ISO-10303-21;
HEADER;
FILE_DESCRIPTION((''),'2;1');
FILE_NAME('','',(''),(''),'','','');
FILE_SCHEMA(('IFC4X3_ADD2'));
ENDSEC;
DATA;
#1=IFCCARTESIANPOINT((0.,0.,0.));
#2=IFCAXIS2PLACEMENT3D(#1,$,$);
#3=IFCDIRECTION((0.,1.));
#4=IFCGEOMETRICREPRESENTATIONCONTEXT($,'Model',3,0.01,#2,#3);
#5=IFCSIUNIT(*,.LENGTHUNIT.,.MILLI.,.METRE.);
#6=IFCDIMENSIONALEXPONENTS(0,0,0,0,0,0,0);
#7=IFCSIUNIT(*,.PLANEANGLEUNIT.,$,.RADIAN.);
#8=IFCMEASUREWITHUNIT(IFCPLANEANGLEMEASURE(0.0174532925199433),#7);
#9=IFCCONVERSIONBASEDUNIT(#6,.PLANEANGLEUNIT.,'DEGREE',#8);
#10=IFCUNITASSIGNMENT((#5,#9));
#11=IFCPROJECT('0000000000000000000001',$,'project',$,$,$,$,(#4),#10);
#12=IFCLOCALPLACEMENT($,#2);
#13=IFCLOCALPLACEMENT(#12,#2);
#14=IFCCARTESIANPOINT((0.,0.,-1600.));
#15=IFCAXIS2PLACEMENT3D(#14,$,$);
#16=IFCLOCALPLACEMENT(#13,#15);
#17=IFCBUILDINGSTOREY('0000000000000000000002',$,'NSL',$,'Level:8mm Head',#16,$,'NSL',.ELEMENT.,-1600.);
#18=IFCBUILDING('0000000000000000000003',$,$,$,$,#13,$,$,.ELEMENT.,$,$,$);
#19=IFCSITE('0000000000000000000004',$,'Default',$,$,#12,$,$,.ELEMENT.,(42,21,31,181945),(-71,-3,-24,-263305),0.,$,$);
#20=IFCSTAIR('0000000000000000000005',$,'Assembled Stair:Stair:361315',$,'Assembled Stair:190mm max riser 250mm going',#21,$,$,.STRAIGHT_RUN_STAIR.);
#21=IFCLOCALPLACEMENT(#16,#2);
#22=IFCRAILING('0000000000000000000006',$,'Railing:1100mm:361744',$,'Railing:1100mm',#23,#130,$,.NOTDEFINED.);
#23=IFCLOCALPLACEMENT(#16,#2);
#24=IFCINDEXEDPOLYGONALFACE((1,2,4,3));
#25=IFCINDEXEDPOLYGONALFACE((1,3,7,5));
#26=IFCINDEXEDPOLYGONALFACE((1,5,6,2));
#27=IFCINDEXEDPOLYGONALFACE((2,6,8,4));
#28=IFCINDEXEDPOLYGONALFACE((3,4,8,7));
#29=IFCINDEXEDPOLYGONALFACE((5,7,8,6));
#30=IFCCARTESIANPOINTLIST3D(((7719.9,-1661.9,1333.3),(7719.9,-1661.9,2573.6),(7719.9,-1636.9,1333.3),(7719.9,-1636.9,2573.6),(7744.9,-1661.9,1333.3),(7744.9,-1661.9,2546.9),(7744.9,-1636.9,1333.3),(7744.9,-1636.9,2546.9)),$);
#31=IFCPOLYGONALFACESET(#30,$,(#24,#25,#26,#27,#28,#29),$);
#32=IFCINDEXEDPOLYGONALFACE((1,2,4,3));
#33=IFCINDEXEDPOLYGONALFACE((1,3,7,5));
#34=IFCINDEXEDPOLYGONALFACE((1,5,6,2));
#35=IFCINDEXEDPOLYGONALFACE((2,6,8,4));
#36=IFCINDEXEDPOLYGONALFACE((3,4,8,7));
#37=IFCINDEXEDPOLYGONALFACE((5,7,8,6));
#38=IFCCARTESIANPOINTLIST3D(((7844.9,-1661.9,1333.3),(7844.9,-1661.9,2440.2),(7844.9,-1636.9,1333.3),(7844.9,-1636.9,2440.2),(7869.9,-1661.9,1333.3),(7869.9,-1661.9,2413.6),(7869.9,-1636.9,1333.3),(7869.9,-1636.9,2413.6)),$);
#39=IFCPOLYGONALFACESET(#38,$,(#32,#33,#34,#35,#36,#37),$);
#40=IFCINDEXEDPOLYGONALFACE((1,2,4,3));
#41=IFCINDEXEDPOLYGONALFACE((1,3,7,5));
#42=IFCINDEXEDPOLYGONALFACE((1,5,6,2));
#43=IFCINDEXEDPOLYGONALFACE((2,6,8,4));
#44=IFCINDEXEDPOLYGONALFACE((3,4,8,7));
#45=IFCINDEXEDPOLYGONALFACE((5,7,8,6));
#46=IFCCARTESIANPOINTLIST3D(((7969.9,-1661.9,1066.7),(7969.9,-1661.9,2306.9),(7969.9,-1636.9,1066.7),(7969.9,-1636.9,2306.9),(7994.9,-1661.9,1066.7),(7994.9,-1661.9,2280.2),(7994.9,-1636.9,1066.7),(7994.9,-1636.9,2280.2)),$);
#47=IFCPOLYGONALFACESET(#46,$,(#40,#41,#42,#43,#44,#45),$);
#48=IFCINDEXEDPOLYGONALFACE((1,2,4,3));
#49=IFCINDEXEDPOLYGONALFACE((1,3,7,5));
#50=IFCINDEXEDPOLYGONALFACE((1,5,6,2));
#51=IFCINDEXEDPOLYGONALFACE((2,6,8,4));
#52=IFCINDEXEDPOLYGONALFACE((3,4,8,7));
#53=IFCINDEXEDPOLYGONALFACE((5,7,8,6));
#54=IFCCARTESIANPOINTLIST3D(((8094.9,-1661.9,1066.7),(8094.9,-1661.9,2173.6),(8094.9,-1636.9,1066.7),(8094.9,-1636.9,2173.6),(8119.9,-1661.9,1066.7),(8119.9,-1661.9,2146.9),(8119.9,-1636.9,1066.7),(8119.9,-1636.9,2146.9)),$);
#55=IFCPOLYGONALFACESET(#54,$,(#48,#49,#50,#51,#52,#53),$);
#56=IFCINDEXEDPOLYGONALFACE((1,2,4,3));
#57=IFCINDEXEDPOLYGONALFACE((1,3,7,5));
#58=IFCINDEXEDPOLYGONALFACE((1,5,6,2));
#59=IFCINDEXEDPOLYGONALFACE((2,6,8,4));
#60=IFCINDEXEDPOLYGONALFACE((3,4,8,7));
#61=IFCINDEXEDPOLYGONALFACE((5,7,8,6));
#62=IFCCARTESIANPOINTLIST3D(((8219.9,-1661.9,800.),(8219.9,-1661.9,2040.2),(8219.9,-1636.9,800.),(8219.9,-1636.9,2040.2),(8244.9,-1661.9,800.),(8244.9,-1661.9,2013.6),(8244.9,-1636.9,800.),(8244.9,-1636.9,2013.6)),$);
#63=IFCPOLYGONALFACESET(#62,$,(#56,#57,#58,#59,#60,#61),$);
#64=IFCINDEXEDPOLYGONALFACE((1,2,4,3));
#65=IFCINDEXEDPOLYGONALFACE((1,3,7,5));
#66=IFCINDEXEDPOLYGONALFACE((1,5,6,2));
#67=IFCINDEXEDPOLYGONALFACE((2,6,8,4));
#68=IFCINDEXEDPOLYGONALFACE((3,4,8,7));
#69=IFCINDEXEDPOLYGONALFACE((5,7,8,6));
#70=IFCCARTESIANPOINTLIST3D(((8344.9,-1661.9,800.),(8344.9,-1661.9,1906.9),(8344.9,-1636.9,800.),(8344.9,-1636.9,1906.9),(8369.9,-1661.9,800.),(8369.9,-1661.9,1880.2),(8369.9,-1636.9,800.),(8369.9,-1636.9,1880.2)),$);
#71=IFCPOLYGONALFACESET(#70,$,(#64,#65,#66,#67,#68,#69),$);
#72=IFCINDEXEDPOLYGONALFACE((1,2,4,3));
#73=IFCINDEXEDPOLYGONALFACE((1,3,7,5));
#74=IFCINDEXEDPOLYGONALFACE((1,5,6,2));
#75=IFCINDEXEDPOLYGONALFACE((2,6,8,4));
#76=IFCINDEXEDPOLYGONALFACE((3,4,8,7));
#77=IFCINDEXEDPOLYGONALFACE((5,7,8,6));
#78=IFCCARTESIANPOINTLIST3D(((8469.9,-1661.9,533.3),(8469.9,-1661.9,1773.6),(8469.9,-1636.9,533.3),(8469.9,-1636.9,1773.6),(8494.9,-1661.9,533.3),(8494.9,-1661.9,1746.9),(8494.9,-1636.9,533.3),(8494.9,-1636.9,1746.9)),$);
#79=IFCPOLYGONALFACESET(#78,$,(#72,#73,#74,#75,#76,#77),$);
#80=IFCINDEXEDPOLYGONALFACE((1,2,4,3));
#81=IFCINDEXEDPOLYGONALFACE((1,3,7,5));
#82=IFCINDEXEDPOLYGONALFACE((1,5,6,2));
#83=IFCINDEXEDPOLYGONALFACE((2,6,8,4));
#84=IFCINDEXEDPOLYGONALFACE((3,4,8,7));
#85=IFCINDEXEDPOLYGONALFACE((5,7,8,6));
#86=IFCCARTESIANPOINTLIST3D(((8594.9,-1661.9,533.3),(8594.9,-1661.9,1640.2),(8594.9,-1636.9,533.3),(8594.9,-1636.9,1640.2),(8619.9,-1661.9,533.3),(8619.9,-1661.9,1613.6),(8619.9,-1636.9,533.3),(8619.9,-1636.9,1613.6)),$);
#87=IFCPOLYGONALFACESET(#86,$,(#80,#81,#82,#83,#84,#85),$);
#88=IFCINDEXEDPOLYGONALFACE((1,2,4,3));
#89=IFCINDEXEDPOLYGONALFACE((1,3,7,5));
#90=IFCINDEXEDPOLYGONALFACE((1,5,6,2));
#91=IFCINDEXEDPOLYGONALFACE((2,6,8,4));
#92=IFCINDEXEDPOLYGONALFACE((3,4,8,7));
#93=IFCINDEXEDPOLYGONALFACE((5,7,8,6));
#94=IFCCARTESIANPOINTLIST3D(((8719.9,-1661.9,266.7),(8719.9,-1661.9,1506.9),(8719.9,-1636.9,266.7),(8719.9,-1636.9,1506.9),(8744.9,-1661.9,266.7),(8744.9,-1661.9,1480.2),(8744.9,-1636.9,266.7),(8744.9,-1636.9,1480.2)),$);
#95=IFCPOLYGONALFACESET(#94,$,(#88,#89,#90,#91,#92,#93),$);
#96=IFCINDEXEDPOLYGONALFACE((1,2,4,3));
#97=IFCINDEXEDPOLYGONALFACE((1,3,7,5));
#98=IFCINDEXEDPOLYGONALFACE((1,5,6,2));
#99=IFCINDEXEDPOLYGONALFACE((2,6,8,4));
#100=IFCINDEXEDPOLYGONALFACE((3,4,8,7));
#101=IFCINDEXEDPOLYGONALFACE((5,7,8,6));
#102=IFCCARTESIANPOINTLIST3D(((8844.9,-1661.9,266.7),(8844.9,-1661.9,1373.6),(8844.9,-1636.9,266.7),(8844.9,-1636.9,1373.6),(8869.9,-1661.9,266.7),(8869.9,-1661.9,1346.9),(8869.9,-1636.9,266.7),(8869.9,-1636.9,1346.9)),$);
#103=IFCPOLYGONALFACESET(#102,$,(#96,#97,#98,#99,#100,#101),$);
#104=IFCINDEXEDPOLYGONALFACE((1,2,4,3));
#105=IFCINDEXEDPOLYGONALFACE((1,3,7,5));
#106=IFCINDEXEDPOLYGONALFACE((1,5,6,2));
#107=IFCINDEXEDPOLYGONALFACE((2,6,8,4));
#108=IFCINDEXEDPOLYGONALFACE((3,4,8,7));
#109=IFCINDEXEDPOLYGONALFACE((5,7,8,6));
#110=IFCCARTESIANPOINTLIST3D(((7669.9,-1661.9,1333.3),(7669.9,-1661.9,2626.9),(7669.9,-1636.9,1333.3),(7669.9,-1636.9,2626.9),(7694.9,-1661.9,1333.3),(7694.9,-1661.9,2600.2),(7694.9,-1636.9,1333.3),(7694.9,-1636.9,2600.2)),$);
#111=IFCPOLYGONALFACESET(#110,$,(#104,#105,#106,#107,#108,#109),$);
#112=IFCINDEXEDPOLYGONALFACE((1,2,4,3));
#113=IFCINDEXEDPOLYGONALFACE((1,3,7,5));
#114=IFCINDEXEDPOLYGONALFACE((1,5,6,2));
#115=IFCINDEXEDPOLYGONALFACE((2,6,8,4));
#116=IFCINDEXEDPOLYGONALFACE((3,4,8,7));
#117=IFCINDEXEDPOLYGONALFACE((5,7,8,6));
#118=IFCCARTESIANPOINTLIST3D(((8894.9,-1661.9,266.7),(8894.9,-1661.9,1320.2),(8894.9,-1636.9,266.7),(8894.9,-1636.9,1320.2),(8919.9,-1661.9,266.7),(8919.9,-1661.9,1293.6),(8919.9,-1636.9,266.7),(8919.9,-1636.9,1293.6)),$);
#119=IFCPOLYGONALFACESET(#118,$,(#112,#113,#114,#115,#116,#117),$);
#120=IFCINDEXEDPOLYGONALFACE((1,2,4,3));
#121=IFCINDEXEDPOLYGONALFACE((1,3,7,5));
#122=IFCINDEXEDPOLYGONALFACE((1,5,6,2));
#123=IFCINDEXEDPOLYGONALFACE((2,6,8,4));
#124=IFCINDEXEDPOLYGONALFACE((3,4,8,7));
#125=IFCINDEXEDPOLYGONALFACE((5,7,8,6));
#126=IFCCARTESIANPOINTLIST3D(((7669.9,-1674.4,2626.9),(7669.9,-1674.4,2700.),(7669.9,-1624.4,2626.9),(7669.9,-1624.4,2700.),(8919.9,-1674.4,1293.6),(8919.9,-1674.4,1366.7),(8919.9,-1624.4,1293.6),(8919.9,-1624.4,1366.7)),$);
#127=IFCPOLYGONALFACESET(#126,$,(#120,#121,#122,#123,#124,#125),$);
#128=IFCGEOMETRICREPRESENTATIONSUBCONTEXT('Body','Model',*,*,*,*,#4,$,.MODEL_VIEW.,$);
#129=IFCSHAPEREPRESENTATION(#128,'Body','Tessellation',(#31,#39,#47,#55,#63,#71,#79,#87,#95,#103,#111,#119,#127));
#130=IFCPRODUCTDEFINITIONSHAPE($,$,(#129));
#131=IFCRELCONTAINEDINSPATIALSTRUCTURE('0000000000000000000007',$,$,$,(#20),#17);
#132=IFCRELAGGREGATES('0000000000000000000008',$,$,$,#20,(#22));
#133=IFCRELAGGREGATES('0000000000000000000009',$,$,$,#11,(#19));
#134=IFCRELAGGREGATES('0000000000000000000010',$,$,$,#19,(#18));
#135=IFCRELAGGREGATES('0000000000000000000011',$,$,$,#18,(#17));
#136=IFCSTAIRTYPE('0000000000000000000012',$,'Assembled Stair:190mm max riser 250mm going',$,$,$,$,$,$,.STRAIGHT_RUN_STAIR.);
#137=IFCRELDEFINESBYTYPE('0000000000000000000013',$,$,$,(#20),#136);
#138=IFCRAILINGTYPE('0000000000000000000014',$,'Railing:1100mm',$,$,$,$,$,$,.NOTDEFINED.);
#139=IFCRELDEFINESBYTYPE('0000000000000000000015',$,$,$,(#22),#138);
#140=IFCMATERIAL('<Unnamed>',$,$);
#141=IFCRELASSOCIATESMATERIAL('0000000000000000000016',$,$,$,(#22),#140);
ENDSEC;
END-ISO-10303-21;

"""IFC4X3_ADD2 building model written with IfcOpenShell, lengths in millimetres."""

from ifc_helpers import new_model, entity, si_unit, converted_unit, direction, frame, origin, place, context, subcontext, project, spatial, polyline, outline, extrude, material, type_object, element, aggregate, save


model = new_model("IFC4X3_ADD2")

# Units and contexts
model_context = context("Model", 3, precision=0.01, world=origin(), true_north=direction((0.0, 1.0)))
body_context = subcontext(model_context, "Body", "Model", "MODEL_VIEW")
ifc_project = project(units=[si_unit("LENGTHUNIT", "METRE", prefix="MILLI"), converted_unit("PLANEANGLEUNIT", "DEGREE", entity("IfcPlaneAngleMeasure", 0.0174532925199433), si_unit("PLANEANGLEUNIT", "RADIAN"), dimensions=[0, 0, 0, 0, 0, 0, 0])], contexts=[model_context])

# Site, building, storey
site_placement = place(None, origin())
site = spatial("IfcSite", under=ifc_project, at=site_placement, Name="Default", CompositionType="ELEMENT", RefLatitude=(42, 21, 31, 181945), RefLongitude=(-71, -3, -24, -263305), RefElevation=0.0)
building_placement = place(site_placement, origin())
building = spatial("IfcBuilding", under=site, at=building_placement, CompositionType="ELEMENT")
storey_placement = place(building_placement, frame((0.0, 0.0, -1600.0)))
storey = spatial("IfcBuildingStorey", under=building, at=storey_placement, Name="NSL", ObjectType="Level:8mm Head", LongName="NSL", CompositionType="ELEMENT", Elevation=-1600.0)

# Stair
stair_type = type_object("IfcStairType", Name="Assembled Stair:190mm max riser 250mm going", PredefinedType="STRAIGHT_RUN_STAIR")
stair_placement = place(storey_placement, origin())
stair = element("IfcStair", 1, at=stair_placement, inside=storey, type_object=stair_type, Name="Assembled Stair:Stair:361315", ObjectType="Assembled Stair:190mm max riser 250mm going", PredefinedType="STRAIGHT_RUN_STAIR")
ifc_material_1 = material(Name="<Unnamed>")

# Railing
railing_type = type_object("IfcRailingType", Name="Railing:1100mm", PredefinedType="NOTDEFINED")
railing_1_placement = place(stair_placement, frame((7669.9, -1674.4, 266.7)))
railing_1 = element("IfcRailing", 2, at=railing_1_placement, type_object=railing_type, material=ifc_material_1, Name="Railing:1100mm:361744", ObjectType="Railing:1100mm", PredefinedType="NOTDEFINED", context=body_context, shape_type="SweptSolid", body=[
    extrude(outline(polyline([(-12.5, -613.4), (12.5, -613.4), (12.5, 626.8), (-12.5, 600.1), (-12.5, -613.4)])), frame((62.5, 12.5, 1680.1), z_axis=(0.0, 1.0, 0.0), x_axis=(-1.0, 0.0, 0.0)), (0.0, 0.0, 1.0), 25.0),
    extrude(outline(polyline([(-12.5, -546.8), (12.5, -546.8), (12.5, 560.1), (-12.5, 533.4), (-12.5, -546.8)])), frame((187.5, 12.5, 1613.4), z_axis=(0.0, 1.0, 0.0), x_axis=(-1.0, 0.0, 0.0)), (0.0, 0.0, 1.0), 25.0),
    extrude(outline(polyline([(-12.5, -613.4), (12.5, -613.4), (12.5, 626.8), (-12.5, 600.1), (-12.5, -613.4)])), frame((312.5, 12.5, 1413.4), z_axis=(0.0, 1.0, 0.0), x_axis=(-1.0, 0.0, 0.0)), (0.0, 0.0, 1.0), 25.0),
    extrude(outline(polyline([(-12.5, -546.8), (12.5, -546.8), (12.5, 560.1), (-12.5, 533.4), (-12.5, -546.8)])), frame((437.5, 12.5, 1346.8), z_axis=(0.0, 1.0, 0.0), x_axis=(-1.0, 0.0, 0.0)), (0.0, 0.0, 1.0), 25.0),
    extrude(outline(polyline([(-12.5, -613.4), (12.5, -613.4), (12.5, 626.8), (-12.5, 600.1), (-12.5, -613.4)])), frame((562.5, 12.5, 1146.8), z_axis=(0.0, 1.0, 0.0), x_axis=(-1.0, 0.0, 0.0)), (0.0, 0.0, 1.0), 25.0),
    extrude(outline(polyline([(-12.5, -546.8), (12.5, -546.8), (12.5, 560.1), (-12.5, 533.4), (-12.5, -546.8)])), frame((687.5, 12.5, 1080.1), z_axis=(0.0, 1.0, 0.0), x_axis=(-1.0, 0.0, 0.0)), (0.0, 0.0, 1.0), 25.0),
    extrude(outline(polyline([(-12.5, -613.4), (12.5, -613.4), (12.5, 626.8), (-12.5, 600.1), (-12.5, -613.4)])), frame((812.5, 12.5, 880.1), z_axis=(0.0, 1.0, 0.0), x_axis=(-1.0, 0.0, 0.0)), (0.0, 0.0, 1.0), 25.0),
    extrude(outline(polyline([(-12.5, -546.8), (12.5, -546.8), (12.5, 560.1), (-12.5, 533.4), (-12.5, -546.8)])), frame((937.5, 12.5, 813.4), z_axis=(0.0, 1.0, 0.0), x_axis=(-1.0, 0.0, 0.0)), (0.0, 0.0, 1.0), 25.0),
    extrude(outline(polyline([(-12.5, -613.4), (12.5, -613.4), (12.5, 626.8), (-12.5, 600.1), (-12.5, -613.4)])), frame((1062.5, 12.5, 613.4), z_axis=(0.0, 1.0, 0.0), x_axis=(-1.0, 0.0, 0.0)), (0.0, 0.0, 1.0), 25.0),
    extrude(outline(polyline([(-12.5, -546.8), (12.5, -546.8), (12.5, 560.1), (-12.5, 533.4), (-12.5, -546.8)])), frame((1187.5, 12.5, 546.8), z_axis=(0.0, 1.0, 0.0), x_axis=(-1.0, 0.0, 0.0)), (0.0, 0.0, 1.0), 25.0),
    extrude(outline(polyline([(-12.5, -640.1), (12.5, -640.1), (12.5, 653.4), (-12.5, 626.8), (-12.5, -640.1)])), frame((12.5, 12.5, 1706.8), z_axis=(0.0, 1.0, 0.0), x_axis=(-1.0, 0.0, 0.0)), (0.0, 0.0, 1.0), 25.0),
    extrude(outline(polyline([(-12.5, -520.1), (12.5, -520.1), (12.5, 533.4), (-12.5, 506.8), (-12.5, -520.1)])), frame((1237.5, 12.5, 520.1), z_axis=(0.0, 1.0, 0.0), x_axis=(-1.0, 0.0, 0.0)), (0.0, 0.0, 1.0), 25.0),
    extrude(outline(polyline([(-940.5, -25.0), (887.2, -25.0), (940.5, 25.0), (-887.2, 25.0), (-940.5, -25.0)])), frame((625.0, 0.0, 1730.1), z_axis=(0.0, 1.0, 0.0), x_axis=(-0.683941, 0.0, 0.729537)), (0.0, 0.0, 1.0), 50.0),
])
aggregate(stair, [railing_1])

save(model, "model.ifc")
